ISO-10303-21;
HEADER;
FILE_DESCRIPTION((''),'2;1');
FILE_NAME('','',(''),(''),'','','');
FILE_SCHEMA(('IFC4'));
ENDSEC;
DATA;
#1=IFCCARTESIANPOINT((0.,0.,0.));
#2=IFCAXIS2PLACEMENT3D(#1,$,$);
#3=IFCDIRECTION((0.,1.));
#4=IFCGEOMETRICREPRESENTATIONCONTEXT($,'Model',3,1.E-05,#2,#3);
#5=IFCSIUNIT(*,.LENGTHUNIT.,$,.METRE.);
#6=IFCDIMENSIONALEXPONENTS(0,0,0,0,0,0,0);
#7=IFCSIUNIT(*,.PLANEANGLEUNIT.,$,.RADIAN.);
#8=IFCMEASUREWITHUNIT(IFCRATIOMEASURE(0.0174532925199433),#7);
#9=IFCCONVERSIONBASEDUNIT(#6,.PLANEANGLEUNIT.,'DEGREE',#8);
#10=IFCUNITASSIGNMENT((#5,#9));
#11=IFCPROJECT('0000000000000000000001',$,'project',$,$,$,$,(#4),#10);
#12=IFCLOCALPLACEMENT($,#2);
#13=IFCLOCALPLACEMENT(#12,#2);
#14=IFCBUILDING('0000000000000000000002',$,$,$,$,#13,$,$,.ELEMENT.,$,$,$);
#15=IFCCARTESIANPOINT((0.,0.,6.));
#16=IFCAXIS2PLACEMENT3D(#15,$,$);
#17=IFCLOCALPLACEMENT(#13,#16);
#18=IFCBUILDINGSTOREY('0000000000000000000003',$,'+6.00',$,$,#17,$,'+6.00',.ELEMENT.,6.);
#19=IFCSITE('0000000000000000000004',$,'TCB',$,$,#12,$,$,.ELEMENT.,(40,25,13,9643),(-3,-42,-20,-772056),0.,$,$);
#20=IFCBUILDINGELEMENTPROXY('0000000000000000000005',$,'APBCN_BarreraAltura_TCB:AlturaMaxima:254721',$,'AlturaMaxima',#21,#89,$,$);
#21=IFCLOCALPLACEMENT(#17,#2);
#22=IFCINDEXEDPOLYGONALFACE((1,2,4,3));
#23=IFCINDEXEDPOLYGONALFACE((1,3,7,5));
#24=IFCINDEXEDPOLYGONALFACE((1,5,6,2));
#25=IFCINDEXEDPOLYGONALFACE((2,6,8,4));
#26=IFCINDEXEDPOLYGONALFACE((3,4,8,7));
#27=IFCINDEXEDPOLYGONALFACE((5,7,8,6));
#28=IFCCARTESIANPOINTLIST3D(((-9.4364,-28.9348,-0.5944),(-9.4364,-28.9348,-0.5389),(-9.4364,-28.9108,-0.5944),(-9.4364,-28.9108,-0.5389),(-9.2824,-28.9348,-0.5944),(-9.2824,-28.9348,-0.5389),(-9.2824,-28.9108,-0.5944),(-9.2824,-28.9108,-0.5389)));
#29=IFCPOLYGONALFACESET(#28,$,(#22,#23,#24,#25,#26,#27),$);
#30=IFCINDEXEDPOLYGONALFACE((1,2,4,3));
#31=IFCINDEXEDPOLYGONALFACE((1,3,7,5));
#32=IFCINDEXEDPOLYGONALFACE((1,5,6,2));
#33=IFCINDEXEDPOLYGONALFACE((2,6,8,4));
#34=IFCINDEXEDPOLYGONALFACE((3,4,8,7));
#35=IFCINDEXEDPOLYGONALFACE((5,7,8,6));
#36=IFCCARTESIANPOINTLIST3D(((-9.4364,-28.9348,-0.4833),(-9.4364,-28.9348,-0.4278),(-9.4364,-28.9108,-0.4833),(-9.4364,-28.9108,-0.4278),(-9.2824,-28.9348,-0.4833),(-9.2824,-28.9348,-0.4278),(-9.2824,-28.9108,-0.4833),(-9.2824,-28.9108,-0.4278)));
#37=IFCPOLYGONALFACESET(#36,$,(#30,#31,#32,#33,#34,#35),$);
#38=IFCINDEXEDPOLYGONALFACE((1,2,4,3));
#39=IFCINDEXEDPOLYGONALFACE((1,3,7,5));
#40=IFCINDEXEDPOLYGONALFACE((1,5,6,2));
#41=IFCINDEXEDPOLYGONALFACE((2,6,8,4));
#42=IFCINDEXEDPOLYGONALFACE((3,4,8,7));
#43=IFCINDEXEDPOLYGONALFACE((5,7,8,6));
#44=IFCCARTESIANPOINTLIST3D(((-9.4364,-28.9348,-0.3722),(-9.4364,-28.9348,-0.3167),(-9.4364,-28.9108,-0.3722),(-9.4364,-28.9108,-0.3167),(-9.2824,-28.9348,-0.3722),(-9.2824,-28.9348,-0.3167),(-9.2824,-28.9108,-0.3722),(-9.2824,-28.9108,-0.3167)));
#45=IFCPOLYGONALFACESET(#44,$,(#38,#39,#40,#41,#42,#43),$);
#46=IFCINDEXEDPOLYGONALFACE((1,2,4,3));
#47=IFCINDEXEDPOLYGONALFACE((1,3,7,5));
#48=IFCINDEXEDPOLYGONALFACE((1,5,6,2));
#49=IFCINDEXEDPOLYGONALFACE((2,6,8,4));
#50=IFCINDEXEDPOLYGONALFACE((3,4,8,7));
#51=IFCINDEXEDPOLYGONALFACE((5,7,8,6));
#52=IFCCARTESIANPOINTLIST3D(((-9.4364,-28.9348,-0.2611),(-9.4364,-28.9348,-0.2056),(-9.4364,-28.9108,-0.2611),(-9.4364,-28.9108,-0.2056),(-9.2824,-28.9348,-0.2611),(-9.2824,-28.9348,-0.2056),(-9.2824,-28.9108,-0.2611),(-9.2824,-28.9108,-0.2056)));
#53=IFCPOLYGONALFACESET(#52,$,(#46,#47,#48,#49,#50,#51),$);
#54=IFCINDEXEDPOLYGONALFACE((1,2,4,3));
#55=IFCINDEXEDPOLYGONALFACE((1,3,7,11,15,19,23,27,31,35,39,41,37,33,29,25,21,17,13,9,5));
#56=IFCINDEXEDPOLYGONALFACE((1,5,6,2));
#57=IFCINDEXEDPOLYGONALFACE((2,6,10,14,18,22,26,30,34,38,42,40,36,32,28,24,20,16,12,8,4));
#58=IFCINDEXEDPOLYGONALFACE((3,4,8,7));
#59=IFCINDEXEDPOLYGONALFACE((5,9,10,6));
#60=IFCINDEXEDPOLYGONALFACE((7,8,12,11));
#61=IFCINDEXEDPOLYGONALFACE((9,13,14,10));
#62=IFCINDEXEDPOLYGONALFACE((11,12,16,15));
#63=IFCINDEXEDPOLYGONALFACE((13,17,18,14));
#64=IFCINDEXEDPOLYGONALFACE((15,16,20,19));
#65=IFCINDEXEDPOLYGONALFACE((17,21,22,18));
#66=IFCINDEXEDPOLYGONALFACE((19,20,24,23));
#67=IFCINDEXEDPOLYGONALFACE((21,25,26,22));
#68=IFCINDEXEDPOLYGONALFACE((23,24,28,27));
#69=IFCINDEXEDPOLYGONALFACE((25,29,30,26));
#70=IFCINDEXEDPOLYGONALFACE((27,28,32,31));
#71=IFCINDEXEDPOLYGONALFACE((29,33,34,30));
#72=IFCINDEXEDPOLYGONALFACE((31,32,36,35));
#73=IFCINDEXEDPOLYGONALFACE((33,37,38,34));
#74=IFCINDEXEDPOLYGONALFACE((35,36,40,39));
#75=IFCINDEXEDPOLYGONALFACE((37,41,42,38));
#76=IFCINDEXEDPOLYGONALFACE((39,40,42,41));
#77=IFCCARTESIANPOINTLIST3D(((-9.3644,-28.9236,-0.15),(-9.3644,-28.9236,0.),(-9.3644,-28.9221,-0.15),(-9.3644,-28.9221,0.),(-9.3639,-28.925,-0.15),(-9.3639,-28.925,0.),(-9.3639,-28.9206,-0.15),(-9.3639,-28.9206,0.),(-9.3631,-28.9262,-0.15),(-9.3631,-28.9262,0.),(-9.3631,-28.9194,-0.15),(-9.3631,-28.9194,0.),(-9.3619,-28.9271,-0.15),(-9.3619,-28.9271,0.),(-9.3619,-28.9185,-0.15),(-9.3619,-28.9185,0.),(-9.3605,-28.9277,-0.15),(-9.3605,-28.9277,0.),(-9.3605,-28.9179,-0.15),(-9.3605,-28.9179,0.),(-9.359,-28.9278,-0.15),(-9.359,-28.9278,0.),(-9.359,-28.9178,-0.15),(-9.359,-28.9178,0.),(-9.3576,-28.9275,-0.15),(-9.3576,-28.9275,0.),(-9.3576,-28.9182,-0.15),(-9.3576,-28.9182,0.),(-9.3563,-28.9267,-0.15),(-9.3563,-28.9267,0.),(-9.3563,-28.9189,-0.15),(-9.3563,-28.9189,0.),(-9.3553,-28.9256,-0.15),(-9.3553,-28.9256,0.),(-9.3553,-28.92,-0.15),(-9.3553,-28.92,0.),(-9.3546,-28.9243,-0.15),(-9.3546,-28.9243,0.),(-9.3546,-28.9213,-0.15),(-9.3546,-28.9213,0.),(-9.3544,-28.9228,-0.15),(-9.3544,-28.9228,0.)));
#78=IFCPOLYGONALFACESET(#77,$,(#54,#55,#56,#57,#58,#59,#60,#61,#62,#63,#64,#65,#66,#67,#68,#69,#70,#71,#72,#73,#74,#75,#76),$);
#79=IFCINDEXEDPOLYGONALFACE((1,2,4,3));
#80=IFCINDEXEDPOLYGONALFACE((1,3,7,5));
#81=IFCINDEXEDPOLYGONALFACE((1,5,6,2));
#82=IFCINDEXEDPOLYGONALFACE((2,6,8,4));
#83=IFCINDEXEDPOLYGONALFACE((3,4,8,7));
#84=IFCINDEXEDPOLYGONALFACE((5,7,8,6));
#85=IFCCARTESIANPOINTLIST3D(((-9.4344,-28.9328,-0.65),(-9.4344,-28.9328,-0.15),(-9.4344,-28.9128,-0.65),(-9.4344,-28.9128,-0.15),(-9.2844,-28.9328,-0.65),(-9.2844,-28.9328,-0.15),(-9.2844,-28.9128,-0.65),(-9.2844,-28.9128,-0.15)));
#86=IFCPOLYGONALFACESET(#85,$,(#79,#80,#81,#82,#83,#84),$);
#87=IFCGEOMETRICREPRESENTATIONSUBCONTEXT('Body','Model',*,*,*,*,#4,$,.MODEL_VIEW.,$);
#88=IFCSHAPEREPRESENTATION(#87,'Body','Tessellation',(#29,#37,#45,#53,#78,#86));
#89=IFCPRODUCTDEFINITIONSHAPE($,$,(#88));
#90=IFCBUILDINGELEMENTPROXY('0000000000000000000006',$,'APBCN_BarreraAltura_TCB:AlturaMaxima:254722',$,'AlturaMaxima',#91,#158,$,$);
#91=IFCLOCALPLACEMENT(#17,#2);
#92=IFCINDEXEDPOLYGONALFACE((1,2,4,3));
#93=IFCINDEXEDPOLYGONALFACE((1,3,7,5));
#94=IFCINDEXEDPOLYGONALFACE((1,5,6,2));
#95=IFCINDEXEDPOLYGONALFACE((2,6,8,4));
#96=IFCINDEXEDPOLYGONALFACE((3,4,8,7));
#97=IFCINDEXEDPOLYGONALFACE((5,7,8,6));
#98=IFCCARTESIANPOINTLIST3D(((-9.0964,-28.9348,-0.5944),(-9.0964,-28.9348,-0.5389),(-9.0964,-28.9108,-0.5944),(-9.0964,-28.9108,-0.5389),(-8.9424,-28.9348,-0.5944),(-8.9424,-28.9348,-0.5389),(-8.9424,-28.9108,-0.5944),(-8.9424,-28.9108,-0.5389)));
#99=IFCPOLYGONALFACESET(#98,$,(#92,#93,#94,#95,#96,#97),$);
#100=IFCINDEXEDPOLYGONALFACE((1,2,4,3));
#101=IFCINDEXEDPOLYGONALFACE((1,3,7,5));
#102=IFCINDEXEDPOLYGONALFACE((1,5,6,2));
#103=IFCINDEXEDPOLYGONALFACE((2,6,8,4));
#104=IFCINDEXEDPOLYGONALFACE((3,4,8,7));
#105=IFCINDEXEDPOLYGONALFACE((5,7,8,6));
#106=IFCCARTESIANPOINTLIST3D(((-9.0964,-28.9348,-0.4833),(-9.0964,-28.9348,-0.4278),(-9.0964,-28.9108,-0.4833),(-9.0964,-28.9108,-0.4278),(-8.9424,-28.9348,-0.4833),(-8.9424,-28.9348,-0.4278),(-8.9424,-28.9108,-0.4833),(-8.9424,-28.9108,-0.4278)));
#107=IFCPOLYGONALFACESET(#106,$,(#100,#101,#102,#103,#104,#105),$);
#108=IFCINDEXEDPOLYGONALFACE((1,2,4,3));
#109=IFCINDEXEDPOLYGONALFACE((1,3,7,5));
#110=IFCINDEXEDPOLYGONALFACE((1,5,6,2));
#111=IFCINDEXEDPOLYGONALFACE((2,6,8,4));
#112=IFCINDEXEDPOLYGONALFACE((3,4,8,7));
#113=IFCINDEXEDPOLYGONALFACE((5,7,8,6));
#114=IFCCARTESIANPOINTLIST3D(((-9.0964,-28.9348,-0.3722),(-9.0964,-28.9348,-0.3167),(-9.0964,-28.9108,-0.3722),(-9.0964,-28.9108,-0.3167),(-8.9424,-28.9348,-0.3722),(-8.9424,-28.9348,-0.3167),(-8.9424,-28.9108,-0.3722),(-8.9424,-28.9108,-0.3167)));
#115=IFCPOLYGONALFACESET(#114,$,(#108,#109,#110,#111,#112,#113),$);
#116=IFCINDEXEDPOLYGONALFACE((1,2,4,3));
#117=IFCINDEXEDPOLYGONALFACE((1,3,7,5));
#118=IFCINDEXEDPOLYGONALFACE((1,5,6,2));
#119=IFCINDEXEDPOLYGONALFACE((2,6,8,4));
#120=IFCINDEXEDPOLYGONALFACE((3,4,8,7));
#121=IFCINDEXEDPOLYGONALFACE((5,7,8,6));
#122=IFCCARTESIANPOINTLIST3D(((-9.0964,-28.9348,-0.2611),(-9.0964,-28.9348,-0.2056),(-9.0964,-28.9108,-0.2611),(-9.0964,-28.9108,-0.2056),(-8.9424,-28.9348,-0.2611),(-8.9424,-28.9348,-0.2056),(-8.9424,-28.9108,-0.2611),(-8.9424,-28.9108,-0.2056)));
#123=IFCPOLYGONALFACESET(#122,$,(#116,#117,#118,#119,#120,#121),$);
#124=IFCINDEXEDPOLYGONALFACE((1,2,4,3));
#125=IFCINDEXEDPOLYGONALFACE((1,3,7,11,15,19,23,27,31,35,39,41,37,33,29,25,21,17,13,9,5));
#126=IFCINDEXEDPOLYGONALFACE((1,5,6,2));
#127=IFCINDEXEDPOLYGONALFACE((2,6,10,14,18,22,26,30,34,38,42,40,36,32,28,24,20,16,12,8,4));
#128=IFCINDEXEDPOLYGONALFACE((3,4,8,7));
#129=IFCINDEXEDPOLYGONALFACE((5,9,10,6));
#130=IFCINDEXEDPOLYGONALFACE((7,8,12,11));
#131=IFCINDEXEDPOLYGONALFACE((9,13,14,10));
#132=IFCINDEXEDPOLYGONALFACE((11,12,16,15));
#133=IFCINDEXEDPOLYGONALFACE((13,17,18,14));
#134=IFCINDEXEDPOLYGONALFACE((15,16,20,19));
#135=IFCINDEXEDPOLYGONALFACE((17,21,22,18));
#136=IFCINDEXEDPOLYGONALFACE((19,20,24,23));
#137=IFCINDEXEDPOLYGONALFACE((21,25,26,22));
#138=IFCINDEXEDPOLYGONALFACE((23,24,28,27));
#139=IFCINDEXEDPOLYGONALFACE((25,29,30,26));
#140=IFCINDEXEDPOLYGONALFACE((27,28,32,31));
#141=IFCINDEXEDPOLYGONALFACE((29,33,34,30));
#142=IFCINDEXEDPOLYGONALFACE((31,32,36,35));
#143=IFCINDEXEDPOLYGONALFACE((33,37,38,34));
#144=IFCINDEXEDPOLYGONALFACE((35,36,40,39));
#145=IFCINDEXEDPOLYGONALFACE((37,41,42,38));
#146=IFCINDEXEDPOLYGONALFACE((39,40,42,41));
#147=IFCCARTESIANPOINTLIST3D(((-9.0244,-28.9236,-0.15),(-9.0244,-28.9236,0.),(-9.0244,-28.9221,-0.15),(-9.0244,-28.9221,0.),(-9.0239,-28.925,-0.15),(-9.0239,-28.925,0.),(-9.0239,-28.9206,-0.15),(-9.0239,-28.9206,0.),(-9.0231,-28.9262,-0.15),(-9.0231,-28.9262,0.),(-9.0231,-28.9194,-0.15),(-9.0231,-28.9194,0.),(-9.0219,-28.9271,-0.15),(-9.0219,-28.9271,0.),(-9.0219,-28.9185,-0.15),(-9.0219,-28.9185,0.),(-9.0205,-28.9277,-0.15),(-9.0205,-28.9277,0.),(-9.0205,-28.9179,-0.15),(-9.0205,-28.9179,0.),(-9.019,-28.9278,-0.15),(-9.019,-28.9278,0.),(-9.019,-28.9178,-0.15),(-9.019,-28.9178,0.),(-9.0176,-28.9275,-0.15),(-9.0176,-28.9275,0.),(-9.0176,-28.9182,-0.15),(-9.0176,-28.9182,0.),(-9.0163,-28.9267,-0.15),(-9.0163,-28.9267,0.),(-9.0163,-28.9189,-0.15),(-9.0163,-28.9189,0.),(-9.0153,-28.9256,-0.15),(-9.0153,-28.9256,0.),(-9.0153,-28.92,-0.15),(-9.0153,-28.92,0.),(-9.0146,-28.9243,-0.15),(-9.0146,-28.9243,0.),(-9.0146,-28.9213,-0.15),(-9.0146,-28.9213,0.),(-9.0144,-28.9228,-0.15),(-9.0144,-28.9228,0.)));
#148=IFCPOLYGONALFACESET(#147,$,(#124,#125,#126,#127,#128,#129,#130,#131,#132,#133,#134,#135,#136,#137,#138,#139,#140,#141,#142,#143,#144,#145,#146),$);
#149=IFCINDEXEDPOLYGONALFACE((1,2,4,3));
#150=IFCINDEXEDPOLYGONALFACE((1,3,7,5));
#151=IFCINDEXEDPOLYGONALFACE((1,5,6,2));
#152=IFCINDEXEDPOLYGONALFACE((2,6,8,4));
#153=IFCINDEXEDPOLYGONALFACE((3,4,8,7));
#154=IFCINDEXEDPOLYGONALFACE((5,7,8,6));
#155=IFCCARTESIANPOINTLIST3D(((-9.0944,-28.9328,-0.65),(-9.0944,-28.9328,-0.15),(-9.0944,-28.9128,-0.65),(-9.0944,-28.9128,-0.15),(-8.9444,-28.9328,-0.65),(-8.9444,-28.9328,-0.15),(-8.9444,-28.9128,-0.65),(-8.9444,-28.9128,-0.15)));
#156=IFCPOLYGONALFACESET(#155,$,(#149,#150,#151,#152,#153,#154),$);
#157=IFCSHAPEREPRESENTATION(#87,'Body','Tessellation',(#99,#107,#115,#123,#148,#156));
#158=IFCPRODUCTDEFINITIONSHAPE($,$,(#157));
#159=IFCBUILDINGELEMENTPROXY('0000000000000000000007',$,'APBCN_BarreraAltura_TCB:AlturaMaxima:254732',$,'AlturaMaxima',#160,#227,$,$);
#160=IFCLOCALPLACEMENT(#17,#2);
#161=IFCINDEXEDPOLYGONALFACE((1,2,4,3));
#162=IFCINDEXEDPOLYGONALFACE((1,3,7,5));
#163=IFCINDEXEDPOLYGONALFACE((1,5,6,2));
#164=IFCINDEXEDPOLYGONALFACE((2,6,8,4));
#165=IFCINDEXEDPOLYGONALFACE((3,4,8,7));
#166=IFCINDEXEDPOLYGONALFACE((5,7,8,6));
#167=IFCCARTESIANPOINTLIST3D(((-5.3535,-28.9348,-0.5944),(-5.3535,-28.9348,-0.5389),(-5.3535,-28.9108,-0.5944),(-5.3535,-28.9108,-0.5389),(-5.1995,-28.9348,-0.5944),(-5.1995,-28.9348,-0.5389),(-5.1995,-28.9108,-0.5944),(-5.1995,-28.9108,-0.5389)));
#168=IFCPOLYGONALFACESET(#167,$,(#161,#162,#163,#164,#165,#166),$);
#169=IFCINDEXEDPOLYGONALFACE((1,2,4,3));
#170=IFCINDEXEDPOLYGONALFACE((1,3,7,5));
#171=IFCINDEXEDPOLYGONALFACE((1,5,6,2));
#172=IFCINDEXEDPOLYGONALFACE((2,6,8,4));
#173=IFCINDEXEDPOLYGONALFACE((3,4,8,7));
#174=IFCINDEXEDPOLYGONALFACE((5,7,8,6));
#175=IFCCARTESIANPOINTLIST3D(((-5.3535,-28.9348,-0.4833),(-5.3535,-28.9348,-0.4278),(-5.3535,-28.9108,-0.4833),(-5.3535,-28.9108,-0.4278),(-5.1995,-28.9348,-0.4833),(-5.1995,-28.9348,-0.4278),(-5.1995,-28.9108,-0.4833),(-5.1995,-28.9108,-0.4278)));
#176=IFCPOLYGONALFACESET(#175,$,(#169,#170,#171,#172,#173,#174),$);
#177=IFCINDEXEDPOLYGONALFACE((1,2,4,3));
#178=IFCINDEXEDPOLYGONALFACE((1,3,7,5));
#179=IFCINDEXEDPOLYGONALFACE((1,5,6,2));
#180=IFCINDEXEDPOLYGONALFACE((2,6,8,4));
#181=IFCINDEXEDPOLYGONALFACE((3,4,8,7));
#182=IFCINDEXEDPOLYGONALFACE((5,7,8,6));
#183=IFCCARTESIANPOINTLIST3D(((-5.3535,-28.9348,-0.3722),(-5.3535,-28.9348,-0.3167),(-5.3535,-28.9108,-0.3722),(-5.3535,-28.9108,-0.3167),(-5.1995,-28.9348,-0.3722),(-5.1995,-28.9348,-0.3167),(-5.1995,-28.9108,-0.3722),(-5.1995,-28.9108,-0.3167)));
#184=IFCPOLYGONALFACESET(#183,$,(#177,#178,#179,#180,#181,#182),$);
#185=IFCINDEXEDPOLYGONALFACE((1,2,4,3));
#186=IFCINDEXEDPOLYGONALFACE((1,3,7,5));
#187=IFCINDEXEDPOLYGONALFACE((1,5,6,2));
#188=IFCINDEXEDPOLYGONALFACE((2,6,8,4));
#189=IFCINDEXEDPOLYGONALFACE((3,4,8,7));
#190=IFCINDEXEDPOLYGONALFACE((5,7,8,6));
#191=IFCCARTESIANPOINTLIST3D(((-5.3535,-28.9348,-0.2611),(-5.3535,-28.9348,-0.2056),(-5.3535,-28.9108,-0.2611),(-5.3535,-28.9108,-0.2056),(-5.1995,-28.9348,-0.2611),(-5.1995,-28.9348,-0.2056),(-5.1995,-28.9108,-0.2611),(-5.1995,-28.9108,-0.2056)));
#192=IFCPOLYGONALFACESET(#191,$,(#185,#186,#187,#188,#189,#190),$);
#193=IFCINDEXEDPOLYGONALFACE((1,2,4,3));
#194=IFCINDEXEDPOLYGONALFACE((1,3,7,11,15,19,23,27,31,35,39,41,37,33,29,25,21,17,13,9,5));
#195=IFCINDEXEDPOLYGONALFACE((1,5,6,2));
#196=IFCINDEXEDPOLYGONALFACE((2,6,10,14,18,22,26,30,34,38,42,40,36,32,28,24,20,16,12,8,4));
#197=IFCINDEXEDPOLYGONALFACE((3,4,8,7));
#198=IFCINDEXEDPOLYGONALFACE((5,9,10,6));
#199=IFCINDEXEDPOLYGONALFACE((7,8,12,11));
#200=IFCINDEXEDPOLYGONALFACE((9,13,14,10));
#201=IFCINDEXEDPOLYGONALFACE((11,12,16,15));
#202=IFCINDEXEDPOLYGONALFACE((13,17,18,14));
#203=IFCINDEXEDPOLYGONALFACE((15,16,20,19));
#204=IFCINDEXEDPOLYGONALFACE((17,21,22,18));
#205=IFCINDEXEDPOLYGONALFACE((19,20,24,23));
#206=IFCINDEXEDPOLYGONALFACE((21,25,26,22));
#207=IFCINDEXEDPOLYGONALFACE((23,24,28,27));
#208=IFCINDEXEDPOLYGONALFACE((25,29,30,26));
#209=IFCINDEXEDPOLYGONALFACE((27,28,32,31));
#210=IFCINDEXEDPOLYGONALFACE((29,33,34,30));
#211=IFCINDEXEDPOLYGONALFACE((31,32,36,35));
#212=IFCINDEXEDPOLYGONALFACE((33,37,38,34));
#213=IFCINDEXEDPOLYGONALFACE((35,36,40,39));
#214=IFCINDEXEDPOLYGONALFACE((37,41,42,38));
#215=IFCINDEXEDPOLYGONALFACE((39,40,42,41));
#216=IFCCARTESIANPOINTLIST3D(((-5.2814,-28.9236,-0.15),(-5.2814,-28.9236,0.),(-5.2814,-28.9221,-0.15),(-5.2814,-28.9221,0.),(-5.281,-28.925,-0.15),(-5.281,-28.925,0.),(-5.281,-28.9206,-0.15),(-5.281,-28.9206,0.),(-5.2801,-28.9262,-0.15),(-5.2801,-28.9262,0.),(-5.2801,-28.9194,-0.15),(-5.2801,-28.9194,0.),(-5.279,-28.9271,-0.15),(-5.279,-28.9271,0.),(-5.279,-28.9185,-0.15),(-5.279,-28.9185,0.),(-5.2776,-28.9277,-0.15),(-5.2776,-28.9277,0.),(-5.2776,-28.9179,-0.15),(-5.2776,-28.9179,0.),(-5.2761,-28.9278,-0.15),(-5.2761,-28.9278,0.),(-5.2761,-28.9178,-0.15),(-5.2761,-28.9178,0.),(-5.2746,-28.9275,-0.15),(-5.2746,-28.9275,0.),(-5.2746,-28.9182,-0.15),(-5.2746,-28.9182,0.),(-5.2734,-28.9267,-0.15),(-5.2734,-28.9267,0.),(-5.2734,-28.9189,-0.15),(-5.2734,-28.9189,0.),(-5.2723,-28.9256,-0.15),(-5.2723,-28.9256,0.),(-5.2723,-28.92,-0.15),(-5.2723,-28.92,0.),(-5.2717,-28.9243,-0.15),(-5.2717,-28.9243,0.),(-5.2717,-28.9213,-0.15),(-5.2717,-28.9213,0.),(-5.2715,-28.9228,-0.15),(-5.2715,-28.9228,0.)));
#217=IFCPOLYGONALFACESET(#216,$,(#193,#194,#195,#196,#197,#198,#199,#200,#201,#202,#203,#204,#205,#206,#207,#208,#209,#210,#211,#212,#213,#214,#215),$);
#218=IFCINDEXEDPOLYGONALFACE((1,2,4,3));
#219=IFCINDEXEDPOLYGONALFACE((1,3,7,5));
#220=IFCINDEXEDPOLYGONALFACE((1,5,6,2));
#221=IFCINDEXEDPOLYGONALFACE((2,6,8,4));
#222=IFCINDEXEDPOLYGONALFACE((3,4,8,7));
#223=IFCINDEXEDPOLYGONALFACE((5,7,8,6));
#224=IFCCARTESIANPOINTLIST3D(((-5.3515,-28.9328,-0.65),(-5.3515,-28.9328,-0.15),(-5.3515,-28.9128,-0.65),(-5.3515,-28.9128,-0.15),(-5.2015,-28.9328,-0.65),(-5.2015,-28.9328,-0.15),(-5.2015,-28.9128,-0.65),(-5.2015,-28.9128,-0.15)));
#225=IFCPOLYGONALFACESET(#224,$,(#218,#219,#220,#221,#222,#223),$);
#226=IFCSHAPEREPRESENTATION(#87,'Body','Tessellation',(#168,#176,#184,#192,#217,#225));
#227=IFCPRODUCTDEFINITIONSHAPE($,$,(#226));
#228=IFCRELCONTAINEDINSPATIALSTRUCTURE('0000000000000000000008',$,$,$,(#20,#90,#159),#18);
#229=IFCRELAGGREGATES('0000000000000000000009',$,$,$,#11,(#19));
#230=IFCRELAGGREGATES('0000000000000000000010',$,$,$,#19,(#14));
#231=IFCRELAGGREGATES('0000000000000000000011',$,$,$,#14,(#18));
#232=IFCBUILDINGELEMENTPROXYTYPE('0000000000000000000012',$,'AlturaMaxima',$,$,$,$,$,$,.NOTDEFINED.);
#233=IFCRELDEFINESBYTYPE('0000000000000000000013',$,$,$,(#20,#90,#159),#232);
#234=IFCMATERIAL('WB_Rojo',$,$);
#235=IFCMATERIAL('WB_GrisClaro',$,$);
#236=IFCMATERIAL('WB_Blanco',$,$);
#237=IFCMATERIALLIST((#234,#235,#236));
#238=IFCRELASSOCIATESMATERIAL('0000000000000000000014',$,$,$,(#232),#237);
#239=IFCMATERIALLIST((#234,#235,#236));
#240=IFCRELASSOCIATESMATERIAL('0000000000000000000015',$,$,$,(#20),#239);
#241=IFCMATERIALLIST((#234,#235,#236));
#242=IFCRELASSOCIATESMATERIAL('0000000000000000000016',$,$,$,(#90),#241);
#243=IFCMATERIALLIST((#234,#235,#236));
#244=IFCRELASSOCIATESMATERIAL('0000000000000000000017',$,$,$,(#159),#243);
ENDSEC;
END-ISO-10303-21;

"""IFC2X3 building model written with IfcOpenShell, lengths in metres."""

from ifc_helpers import new_model, entity, si_unit, converted_unit, direction, frame, frame_2d, origin, origin_2d_with_axis, place, context, subcontext, project, spatial, rectangle, circle, extrude, source, transform, mapped, material, material_list, type_object, type_shapes, element, save


model = new_model("IFC2X3")

# Units and contexts
model_context = context("Model", 3, precision=1e-05, world=origin(), true_north=direction((0.0, 1.0)))
body_context = subcontext(model_context, "Body", "Model", "MODEL_VIEW")
ifc_project = project(units=[si_unit("LENGTHUNIT", "METRE"), converted_unit("PLANEANGLEUNIT", "DEGREE", entity("IfcRatioMeasure", 0.0174532925199433), si_unit("PLANEANGLEUNIT", "RADIAN"), dimensions=[0, 0, 0, 0, 0, 0, 0])], contexts=[model_context])

# Site, building, storey
site_placement = place(None, origin())
site = spatial("IfcSite", under=ifc_project, at=site_placement, Name="TCB", CompositionType="ELEMENT", RefLatitude=(40, 25, 13, 9643), RefLongitude=(-3, -42, -20, -772056), RefElevation=0.0)
building_placement = place(site_placement, origin())
building = spatial("IfcBuilding", under=site, at=building_placement, CompositionType="ELEMENT")
storey_placement = place(building_placement, frame((0.0, 0.0, 6.0)))
storey = spatial("IfcBuildingStorey", under=building, at=storey_placement, Name="+6.00", LongName="+6.00", CompositionType="ELEMENT", Elevation=6.0)

# Building element proxies
ifc_material_1 = material(Name="WB_Rojo")
ifc_material_2 = material(Name="WB_GrisClaro")
ifc_material_3 = material(Name="WB_Blanco")
ifc_material_list_1 = material_list([ifc_material_1, ifc_material_2, ifc_material_3])
building_element_proxy_type = type_object("IfcBuildingElementProxyType", Name="AlturaMaxima", PredefinedType="NOTDEFINED", material=ifc_material_list_1)
shared_shape = source(origin(), body_context, "Body", "SweptSolid", [
    extrude(rectangle(XDim=0.154, YDim=0.024, at=frame_2d((0.0, 0.0), x_axis=(1.0, 0.0))), frame((0.0, 0.0, -0.5944), z_axis=(0.0, 0.0, 1.0), x_axis=(-1.0, 0.0, 0.0)), (0.0, 0.0, 1.0), 0.0556),
    extrude(rectangle(XDim=0.154, YDim=0.024, at=frame_2d((0.0, 0.0), x_axis=(1.0, 0.0))), frame((0.0, 0.0, -0.4833), z_axis=(0.0, 0.0, 1.0), x_axis=(-1.0, 0.0, 0.0)), (0.0, 0.0, 1.0), 0.0556),
    extrude(rectangle(XDim=0.154, YDim=0.024, at=frame_2d((0.0, 0.0), x_axis=(1.0, 0.0))), frame((0.0, 0.0, -0.3722), z_axis=(0.0, 0.0, 1.0), x_axis=(-1.0, 0.0, 0.0)), (0.0, 0.0, 1.0), 0.0556),
    extrude(rectangle(XDim=0.154, YDim=0.024, at=frame_2d((0.0, 0.0), x_axis=(1.0, 0.0))), frame((0.0, 0.0, -0.2611), z_axis=(0.0, 0.0, 1.0), x_axis=(-1.0, 0.0, 0.0)), (0.0, 0.0, 1.0), 0.0556),
    extrude(circle(Radius=0.005, at=frame_2d((0.0, 0.0), x_axis=(1.0, 0.0))), frame((0.0, 0.0, -0.15)), (0.0, 0.0, 1.0), 0.15),
    extrude(rectangle(XDim=0.02, YDim=0.15, at=origin_2d_with_axis()), frame((0.0, 0.0, -0.65), z_axis=(0.0, 0.0, 1.0), x_axis=(0.0, 1.0, 0.0)), (0.0, 0.0, 1.0), 0.5),
])
type_shapes(building_element_proxy_type, [shared_shape])
ifc_material_list_2 = material_list([ifc_material_1, ifc_material_2, ifc_material_3])
proxy_1_placement = place(storey_placement, frame((-9.3594, -28.9228, 0.0)))
element("IfcBuildingElementProxy", 1, at=proxy_1_placement, inside=storey, type_object=building_element_proxy_type, material=ifc_material_list_2, Name="APBCN_BarreraAltura_TCB:AlturaMaxima:254721", ObjectType="AlturaMaxima", context=body_context, shape_type="MappedRepresentation", body=[
    mapped(shared_shape, transform((0.0, 0.0, 0.0), scale=1.0)),
])
ifc_material_list_3 = material_list([ifc_material_1, ifc_material_2, ifc_material_3])
proxy_2_placement = place(storey_placement, frame((-9.0194, -28.9228, 0.0)))
element("IfcBuildingElementProxy", 2, at=proxy_2_placement, inside=storey, type_object=building_element_proxy_type, material=ifc_material_list_3, Name="APBCN_BarreraAltura_TCB:AlturaMaxima:254722", ObjectType="AlturaMaxima", context=body_context, shape_type="MappedRepresentation", body=[
    mapped(shared_shape, transform((0.0, 0.0, 0.0), scale=1.0)),
])
ifc_material_list_4 = material_list([ifc_material_1, ifc_material_2, ifc_material_3])
proxy_3_placement = place(storey_placement, frame((-5.2765, -28.9228, 0.0)))
element("IfcBuildingElementProxy", 3, at=proxy_3_placement, inside=storey, type_object=building_element_proxy_type, material=ifc_material_list_4, Name="APBCN_BarreraAltura_TCB:AlturaMaxima:254732", ObjectType="AlturaMaxima", context=body_context, shape_type="MappedRepresentation", body=[
    mapped(shared_shape, transform((0.0, 0.0, 0.0), scale=1.0)),
])

save(model, "model.ifc")
